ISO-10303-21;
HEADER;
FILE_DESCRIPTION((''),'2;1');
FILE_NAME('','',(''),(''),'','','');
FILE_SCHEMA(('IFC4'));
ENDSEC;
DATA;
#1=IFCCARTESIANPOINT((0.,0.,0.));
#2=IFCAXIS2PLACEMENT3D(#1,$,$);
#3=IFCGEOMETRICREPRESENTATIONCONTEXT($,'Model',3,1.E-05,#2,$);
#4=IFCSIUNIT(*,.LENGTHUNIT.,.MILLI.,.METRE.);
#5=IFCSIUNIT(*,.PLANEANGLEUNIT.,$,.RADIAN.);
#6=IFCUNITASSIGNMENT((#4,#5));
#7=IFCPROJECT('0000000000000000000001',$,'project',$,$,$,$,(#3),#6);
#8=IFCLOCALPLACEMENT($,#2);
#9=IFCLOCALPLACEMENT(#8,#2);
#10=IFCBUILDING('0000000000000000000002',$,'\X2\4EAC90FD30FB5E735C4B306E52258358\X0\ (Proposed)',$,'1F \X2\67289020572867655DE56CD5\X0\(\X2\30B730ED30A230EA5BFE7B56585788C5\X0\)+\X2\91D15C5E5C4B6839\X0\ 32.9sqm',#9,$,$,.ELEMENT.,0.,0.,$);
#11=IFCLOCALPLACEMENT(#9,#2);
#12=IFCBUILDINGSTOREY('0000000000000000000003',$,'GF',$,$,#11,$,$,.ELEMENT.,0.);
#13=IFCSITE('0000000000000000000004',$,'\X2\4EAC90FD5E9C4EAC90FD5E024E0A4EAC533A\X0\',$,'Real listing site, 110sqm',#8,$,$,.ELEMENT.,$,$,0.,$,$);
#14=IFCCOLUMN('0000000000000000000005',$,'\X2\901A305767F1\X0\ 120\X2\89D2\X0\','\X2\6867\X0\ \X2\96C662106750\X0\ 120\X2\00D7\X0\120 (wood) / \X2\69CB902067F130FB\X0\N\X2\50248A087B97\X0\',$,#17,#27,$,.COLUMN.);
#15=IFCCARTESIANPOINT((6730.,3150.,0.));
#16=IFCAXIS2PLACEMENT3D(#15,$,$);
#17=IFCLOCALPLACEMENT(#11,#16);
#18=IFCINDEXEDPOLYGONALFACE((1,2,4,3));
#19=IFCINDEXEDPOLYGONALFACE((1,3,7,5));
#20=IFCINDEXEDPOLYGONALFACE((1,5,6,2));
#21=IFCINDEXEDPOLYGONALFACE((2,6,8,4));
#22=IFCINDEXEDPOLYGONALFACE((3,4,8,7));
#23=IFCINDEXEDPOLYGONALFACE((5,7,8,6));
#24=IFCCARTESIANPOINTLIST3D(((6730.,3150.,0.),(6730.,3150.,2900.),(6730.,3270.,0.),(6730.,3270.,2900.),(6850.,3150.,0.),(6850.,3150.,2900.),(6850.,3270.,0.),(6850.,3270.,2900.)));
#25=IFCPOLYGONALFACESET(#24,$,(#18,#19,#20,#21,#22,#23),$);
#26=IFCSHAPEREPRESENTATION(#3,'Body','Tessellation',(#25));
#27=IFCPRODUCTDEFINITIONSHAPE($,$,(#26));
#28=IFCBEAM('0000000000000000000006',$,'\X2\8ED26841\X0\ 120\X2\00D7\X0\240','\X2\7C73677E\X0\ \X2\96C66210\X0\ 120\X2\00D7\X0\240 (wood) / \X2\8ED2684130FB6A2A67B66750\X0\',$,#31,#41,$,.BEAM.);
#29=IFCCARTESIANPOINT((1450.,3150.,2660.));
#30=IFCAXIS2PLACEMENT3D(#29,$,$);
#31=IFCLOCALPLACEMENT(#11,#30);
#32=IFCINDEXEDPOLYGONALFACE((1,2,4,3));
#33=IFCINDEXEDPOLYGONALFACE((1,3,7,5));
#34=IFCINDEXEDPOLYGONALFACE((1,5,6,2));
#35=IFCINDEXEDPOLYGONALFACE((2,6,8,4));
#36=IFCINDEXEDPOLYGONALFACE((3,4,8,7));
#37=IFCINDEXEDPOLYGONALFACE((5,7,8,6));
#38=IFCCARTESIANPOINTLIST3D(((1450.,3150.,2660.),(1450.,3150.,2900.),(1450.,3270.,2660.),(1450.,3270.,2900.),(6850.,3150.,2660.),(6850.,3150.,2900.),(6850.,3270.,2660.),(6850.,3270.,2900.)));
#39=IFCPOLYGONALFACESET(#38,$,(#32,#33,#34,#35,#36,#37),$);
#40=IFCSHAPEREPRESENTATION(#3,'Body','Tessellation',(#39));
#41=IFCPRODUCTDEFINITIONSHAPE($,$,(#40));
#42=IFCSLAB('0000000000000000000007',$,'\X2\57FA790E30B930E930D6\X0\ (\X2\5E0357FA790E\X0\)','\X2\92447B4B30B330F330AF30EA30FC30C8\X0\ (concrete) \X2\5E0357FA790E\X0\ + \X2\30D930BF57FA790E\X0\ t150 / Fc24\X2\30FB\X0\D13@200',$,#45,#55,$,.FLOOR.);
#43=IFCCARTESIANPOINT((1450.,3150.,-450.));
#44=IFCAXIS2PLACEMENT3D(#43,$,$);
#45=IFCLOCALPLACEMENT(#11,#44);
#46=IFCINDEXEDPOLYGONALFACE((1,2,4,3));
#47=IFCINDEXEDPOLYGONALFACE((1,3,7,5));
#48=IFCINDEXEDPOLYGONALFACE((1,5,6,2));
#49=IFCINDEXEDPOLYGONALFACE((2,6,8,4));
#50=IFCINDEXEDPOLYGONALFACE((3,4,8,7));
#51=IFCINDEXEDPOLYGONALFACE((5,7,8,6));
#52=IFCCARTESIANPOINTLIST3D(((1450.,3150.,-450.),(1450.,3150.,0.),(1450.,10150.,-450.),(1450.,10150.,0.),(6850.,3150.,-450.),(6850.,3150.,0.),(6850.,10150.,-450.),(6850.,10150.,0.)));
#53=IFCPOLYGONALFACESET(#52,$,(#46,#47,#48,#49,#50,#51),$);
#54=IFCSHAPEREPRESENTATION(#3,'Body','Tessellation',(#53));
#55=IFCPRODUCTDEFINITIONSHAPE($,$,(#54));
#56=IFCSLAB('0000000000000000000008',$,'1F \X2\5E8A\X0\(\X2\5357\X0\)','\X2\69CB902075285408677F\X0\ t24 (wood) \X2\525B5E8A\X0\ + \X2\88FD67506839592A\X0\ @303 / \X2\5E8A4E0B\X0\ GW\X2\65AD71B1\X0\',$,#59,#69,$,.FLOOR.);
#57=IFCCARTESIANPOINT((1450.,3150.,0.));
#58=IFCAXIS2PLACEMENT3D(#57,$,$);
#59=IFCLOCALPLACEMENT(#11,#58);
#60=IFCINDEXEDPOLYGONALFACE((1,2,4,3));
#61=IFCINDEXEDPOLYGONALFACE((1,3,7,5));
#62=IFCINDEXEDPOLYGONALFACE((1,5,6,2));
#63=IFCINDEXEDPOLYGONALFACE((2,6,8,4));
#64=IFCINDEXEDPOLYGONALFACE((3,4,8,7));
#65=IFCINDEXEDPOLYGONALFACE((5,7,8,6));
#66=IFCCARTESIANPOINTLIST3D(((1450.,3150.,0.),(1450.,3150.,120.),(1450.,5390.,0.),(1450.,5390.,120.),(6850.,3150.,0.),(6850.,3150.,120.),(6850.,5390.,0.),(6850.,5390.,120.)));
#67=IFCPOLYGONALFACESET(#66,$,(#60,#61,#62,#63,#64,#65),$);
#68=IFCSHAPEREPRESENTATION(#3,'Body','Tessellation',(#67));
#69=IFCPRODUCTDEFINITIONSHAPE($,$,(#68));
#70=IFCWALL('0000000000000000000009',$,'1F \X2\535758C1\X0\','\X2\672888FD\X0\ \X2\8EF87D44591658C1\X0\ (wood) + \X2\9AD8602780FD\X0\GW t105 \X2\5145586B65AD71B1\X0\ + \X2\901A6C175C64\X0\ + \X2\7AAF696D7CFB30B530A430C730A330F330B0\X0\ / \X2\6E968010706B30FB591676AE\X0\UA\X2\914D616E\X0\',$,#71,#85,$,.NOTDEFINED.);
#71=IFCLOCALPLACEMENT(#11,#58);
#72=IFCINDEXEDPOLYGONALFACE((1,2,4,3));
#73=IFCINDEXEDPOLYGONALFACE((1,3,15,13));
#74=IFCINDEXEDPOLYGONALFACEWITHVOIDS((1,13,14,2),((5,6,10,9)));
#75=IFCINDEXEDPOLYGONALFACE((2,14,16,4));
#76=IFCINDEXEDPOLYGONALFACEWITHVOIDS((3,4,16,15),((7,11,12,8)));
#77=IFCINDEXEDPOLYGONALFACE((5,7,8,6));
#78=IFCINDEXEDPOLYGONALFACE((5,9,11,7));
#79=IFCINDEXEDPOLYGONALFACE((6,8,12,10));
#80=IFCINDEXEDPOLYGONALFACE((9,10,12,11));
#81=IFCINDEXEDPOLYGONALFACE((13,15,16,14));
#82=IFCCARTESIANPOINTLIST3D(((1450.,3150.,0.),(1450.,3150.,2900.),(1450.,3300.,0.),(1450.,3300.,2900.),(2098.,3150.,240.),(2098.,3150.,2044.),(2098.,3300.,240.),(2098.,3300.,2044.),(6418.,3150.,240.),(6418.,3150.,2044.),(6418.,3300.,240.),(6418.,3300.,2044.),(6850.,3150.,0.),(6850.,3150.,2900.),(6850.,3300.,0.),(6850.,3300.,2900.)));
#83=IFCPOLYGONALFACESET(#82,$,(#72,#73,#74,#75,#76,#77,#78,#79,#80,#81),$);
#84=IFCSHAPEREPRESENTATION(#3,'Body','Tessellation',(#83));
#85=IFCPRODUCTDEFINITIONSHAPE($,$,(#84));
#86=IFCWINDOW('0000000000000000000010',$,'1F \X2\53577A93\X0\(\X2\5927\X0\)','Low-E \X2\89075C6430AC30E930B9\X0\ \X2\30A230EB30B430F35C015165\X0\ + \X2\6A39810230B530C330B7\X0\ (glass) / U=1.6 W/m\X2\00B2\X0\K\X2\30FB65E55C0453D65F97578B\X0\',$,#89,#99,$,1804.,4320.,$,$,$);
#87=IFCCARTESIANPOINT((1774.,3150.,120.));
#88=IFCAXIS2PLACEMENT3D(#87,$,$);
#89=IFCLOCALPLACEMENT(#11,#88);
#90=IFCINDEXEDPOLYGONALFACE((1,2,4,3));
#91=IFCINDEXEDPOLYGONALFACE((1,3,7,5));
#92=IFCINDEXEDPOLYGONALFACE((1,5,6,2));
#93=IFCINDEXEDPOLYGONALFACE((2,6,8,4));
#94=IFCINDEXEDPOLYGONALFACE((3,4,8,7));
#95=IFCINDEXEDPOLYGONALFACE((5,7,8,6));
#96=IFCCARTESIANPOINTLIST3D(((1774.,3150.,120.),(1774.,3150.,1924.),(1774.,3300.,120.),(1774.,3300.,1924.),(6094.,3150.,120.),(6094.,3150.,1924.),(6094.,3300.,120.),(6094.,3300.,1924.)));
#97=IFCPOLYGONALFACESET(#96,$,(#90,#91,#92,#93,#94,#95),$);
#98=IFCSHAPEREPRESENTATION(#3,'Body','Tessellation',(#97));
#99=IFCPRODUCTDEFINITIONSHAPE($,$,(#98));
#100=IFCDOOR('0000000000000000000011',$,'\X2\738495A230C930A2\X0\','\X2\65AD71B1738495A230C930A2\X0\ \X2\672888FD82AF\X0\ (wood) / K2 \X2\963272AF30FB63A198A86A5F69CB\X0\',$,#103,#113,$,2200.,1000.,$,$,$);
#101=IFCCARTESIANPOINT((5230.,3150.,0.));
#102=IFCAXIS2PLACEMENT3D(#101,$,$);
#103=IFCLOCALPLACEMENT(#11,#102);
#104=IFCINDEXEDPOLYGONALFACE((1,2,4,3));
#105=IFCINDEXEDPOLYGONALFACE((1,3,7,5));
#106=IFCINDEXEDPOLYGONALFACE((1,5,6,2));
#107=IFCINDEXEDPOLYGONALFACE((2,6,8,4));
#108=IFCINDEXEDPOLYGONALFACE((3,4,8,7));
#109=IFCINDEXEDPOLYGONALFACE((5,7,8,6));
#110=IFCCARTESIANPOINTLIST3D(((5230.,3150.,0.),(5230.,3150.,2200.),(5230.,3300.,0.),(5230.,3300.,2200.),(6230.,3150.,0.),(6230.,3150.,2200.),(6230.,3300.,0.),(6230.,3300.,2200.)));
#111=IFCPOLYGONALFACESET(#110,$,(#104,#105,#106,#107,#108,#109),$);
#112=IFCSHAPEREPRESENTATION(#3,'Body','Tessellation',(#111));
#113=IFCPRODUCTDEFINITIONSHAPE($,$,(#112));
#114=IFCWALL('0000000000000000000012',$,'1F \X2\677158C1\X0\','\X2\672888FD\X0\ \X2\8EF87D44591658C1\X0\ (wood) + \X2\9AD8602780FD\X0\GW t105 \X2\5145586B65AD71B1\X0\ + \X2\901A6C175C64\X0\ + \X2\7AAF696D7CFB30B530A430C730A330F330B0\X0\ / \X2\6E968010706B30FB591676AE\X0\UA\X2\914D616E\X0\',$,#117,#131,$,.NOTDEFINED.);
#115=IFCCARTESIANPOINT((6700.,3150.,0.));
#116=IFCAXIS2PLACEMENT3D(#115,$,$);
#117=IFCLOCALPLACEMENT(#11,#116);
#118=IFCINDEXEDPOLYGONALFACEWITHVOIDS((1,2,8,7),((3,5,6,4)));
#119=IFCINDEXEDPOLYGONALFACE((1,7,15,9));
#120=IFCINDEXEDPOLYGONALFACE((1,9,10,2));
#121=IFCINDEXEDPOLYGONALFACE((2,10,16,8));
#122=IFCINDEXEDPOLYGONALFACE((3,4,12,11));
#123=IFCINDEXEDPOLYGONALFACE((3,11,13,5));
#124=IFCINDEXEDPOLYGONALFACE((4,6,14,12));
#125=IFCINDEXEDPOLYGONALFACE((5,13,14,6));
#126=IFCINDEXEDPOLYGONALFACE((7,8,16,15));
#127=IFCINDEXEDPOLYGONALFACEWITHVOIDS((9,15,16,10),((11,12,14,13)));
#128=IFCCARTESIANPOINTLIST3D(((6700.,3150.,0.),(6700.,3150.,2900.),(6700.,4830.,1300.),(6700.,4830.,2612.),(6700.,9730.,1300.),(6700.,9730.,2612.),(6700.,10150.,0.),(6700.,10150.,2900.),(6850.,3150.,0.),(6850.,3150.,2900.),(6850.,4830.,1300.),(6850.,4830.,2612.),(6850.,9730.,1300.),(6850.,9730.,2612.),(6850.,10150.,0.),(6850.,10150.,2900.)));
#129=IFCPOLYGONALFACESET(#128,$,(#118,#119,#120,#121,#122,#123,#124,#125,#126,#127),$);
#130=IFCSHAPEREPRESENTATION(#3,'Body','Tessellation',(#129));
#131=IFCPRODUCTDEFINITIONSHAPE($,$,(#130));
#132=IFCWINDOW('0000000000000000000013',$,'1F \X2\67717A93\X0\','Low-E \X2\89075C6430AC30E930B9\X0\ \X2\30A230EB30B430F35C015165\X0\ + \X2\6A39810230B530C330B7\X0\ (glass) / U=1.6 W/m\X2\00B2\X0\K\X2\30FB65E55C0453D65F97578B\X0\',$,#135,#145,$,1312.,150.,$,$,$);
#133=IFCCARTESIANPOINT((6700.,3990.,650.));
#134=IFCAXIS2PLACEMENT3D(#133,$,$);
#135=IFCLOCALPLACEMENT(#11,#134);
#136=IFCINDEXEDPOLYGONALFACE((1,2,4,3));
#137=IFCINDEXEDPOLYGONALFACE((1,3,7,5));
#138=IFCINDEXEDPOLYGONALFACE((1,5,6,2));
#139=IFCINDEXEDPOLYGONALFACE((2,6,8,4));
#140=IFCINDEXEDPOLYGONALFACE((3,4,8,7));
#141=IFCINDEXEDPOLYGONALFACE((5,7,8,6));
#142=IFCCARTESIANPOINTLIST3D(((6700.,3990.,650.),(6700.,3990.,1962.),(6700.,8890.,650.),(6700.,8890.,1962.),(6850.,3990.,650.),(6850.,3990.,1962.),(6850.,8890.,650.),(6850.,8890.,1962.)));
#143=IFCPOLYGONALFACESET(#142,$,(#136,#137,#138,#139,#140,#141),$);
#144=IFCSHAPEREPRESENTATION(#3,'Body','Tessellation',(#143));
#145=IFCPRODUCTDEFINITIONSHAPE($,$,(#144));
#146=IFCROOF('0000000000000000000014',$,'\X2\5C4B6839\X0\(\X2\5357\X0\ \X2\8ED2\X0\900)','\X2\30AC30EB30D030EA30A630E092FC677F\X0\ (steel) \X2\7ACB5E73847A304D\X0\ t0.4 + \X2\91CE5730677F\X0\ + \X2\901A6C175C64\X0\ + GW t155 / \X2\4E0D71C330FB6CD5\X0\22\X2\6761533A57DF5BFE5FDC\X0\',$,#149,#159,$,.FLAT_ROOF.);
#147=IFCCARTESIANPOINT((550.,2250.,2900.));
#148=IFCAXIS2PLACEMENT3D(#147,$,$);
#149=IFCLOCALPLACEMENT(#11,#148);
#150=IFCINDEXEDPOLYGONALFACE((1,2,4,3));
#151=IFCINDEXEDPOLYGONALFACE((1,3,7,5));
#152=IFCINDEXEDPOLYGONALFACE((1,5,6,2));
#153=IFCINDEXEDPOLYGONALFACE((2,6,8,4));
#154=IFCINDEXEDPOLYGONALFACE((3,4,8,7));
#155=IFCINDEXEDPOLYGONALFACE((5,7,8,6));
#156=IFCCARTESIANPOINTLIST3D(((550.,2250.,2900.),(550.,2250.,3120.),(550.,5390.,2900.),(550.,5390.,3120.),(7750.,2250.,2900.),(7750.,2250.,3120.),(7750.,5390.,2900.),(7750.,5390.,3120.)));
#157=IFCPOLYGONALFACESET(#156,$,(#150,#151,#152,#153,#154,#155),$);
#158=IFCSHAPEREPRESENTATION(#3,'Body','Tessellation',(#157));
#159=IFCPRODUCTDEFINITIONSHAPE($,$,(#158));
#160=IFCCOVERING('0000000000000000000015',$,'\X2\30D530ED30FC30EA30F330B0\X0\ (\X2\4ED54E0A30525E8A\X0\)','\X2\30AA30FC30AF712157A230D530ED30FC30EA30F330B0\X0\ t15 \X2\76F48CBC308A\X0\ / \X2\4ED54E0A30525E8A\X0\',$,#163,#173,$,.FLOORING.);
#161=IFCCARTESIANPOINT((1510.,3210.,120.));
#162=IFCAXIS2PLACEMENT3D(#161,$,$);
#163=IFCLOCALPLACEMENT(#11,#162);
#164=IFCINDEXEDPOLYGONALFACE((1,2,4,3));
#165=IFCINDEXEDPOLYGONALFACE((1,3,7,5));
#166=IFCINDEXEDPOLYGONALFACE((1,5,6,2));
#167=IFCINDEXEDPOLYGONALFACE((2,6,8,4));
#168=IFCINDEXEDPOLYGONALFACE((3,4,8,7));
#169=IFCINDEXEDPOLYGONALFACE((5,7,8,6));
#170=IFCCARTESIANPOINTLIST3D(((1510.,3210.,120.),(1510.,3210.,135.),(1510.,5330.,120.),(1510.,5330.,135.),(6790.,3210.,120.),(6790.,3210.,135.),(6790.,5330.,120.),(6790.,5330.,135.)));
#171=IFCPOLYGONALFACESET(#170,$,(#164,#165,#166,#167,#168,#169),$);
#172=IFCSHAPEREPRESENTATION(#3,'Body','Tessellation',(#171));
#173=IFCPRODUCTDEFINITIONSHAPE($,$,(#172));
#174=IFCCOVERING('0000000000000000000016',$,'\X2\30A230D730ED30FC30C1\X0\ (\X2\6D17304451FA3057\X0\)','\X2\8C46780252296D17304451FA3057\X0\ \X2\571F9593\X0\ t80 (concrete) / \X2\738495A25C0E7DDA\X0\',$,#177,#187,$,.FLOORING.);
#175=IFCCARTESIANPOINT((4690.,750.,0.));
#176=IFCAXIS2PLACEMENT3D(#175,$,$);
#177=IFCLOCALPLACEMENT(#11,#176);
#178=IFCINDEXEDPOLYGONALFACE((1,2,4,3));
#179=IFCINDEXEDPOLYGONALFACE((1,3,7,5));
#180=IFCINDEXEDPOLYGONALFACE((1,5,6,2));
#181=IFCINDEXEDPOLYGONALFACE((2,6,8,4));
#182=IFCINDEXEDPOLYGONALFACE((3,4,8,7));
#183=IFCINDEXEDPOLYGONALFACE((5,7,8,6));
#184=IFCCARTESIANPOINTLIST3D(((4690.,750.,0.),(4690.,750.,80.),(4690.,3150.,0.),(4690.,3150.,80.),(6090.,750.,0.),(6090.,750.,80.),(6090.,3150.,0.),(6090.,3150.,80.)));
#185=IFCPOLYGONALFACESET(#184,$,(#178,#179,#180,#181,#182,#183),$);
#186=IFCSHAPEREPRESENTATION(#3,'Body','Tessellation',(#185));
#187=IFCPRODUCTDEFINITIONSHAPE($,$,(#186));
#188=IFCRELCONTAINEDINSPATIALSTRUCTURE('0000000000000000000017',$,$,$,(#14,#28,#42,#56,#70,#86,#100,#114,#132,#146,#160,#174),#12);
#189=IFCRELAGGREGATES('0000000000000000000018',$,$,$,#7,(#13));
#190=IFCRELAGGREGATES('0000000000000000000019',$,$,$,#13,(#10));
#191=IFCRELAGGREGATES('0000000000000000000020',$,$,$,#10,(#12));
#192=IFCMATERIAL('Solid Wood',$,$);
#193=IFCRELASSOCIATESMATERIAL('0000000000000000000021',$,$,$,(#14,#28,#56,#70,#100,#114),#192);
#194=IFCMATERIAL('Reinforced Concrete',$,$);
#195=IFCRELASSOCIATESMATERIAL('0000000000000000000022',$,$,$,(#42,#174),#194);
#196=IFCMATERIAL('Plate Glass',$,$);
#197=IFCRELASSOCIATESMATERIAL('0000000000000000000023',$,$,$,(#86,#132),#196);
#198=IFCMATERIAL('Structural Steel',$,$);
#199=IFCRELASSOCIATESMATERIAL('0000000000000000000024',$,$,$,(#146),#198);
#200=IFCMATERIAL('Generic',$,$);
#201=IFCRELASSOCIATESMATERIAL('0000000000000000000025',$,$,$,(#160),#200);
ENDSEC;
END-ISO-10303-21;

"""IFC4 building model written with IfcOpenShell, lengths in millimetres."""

from ifc_helpers import new_model, si_unit, frame, frame_2d, origin, place, context, project, spatial, rectangle, extrude, material, element, fill, save


model = new_model("IFC4")

# Units and contexts
model_context = context("Model", 3, precision=1e-05, world=origin())
ifc_project = project(units=[si_unit("LENGTHUNIT", "METRE", prefix="MILLI"), si_unit("PLANEANGLEUNIT", "RADIAN")], contexts=[model_context])

# Site, building, storey
site_placement = place(None, origin())
site = spatial("IfcSite", under=ifc_project, at=site_placement, Name="京都府京都市上京区", ObjectType="Real listing site, 110sqm", CompositionType="ELEMENT", RefElevation=0.0)
building_placement = place(site_placement, origin())
building = spatial("IfcBuilding", under=site, at=building_placement, Name="京都・平屋の別荘 (Proposed)", ObjectType="1F 木造在来工法(シロアリ対策塗装)+金属屋根 32.9sqm", CompositionType="ELEMENT", ElevationOfRefHeight=0.0, ElevationOfTerrain=0.0)
storey_placement = place(building_placement, origin())
storey = spatial("IfcBuildingStorey", under=building, at=storey_placement, Name="GF", CompositionType="ELEMENT", Elevation=0.0)

# Column
ifc_material_1 = material(Name="Solid Wood")
column_1_placement = place(storey_placement, frame((6730.0, 3150.0, 0.0)))
element("IfcColumn", 1, at=column_1_placement, inside=storey, material=ifc_material_1, Name="通し柱 120角", Description="桧 集成材 120×120 (wood) / 構造柱・N値計算", PredefinedType="COLUMN", context=model_context, shape_type="SweptSolid", body=[
    extrude(rectangle(XDim=120.0, YDim=120.0, at=frame_2d((60.0, 60.0))), frame((6730.0, 3150.0, 0.0)), (0.0, 0.0, 1.0), 2900.0),
])

# Beam
beam_1_placement = place(storey_placement, frame((1450.0, 3150.0, 2660.0)))
element("IfcBeam", 2, at=beam_1_placement, inside=storey, material=ifc_material_1, Name="軒桁 120×240", Description="米松 集成 120×240 (wood) / 軒桁・横架材", PredefinedType="BEAM", context=model_context, shape_type="SweptSolid", body=[
    extrude(rectangle(XDim=5400.0, YDim=120.0, at=frame_2d((2700.0, 60.0))), frame((1450.0, 3150.0, 2660.0)), (0.0, 0.0, 1.0), 240.0),
])

# Slabs
ifc_material_2 = material(Name="Reinforced Concrete")
slab_1_placement = place(storey_placement, frame((1450.0, 3150.0, -450.0)))
element("IfcSlab", 3, at=slab_1_placement, inside=storey, material=ifc_material_2, Name="基礎スラブ (布基礎)", Description="鉄筋コンクリート (concrete) 布基礎 + ベタ基礎 t150 / Fc24・D13@200", PredefinedType="FLOOR", context=model_context, shape_type="SweptSolid", body=[
    extrude(rectangle(XDim=5400.0, YDim=7000.0, at=frame_2d((2700.0, 3500.0))), frame((1450.0, 3150.0, -450.0)), (0.0, 0.0, 1.0), 450.0),
])
slab_2_placement = place(storey_placement, frame((1450.0, 3150.0, 0.0)))
element("IfcSlab", 4, at=slab_2_placement, inside=storey, material=ifc_material_1, Name="1F 床(南)", Description="構造用合板 t24 (wood) 剛床 + 製材根太 @303 / 床下 GW断熱", PredefinedType="FLOOR", context=model_context, shape_type="SweptSolid", body=[
    extrude(rectangle(XDim=5400.0, YDim=2240.0, at=frame_2d((2700.0, 1120.0))), frame((1450.0, 3150.0, 0.0)), (0.0, 0.0, 1.0), 120.0),
])

# Wall, openings, window, door
wall_1_placement = place(storey_placement, frame((1450.0, 3150.0, 0.0)))
wall_1 = element("IfcWall", 5, at=wall_1_placement, inside=storey, material=ifc_material_1, Name="1F 南壁", Description="木製 軸組外壁 (wood) + 高性能GW t105 充填断熱 + 通気層 + 窯業系サイディング / 準耐火・外皮UA配慮", PredefinedType="NOTDEFINED", context=model_context, shape_type="SweptSolid", body=[
    extrude(rectangle(XDim=5400.0, YDim=150.0, at=frame_2d((2700.0, 75.0))), frame((1450.0, 3150.0, 0.0)), (0.0, 0.0, 1.0), 2900.0),
])
opening_1_placement = place(storey_placement, frame((1774.0, 3150.0, 120.0)))
opening_1 = element("IfcOpeningElement", 6, at=opening_1_placement, cuts=wall_1, PredefinedType="NOTDEFINED", context=model_context, shape_type="SweptSolid", body=[
    extrude(rectangle(XDim=4320.0, YDim=150.0, at=frame_2d((2160.0, 75.0))), frame((1774.0, 3150.0, 120.0)), (0.0, 0.0, 1.0), 1804.0),
])
opening_2_placement = place(storey_placement, frame((5230.0, 3150.0, 0.0)))
opening_2 = element("IfcOpeningElement", 7, at=opening_2_placement, cuts=wall_1, PredefinedType="NOTDEFINED", context=model_context, shape_type="SweptSolid", body=[
    extrude(rectangle(XDim=1000.0, YDim=150.0, at=frame_2d((500.0, 75.0))), frame((5230.0, 3150.0, 0.0)), (0.0, 0.0, 1.0), 2200.0),
])
ifc_material_3 = material(Name="Plate Glass")
window_1_placement = place(storey_placement, frame((1774.0, 3150.0, 120.0)))
window_1 = element("IfcWindow", 8, at=window_1_placement, inside=storey, material=ifc_material_3, Name="1F 南窓(大)", Description="Low-E 複層ガラス アルゴン封入 + 樹脂サッシ (glass) / U=1.6 W/m²K・日射取得型", OverallHeight=1804.0, OverallWidth=4320.0, context=model_context, shape_type="SweptSolid", body=[
    extrude(rectangle(XDim=4320.0, YDim=150.0, at=frame_2d((2160.0, 75.0))), frame((1774.0, 3150.0, 120.0)), (0.0, 0.0, 1.0), 1804.0),
])
fill(opening_1, window_1)
door_placement = place(storey_placement, frame((5230.0, 3150.0, 0.0)))
door = element("IfcDoor", 9, at=door_placement, inside=storey, material=ifc_material_1, Name="玄関ドア", Description="断熱玄関ドア 木製芯 (wood) / K2 防犯・採風機構", OverallHeight=2200.0, OverallWidth=1000.0, context=model_context, shape_type="SweptSolid", body=[
    extrude(rectangle(XDim=1000.0, YDim=150.0, at=frame_2d((500.0, 75.0))), frame((5230.0, 3150.0, 0.0)), (0.0, 0.0, 1.0), 2200.0),
])
fill(opening_2, door)

# Wall, opening, window
wall_2_placement = place(storey_placement, frame((6700.0, 3150.0, 0.0)))
wall_2 = element("IfcWall", 10, at=wall_2_placement, inside=storey, material=ifc_material_1, Name="1F 東壁", Description="木製 軸組外壁 (wood) + 高性能GW t105 充填断熱 + 通気層 + 窯業系サイディング / 準耐火・外皮UA配慮", PredefinedType="NOTDEFINED", context=model_context, shape_type="SweptSolid", body=[
    extrude(rectangle(XDim=150.0, YDim=7000.0, at=frame_2d((75.0, 3500.0))), frame((6700.0, 3150.0, 0.0)), (0.0, 0.0, 1.0), 2900.0),
])
opening_3_placement = place(storey_placement, frame((6700.0, 3990.0, 650.0)))
opening_3 = element("IfcOpeningElement", 11, at=opening_3_placement, cuts=wall_2, PredefinedType="NOTDEFINED", context=model_context, shape_type="SweptSolid", body=[
    extrude(rectangle(XDim=150.0, YDim=4900.0, at=frame_2d((75.0, 2450.0))), frame((6700.0, 3990.0, 650.0)), (0.0, 0.0, 1.0), 1312.0),
])
window_2_placement = place(storey_placement, frame((6700.0, 3990.0, 650.0)))
window_2 = element("IfcWindow", 12, at=window_2_placement, inside=storey, material=ifc_material_3, Name="1F 東窓", Description="Low-E 複層ガラス アルゴン封入 + 樹脂サッシ (glass) / U=1.6 W/m²K・日射取得型", OverallHeight=1312.0, OverallWidth=150.0, context=model_context, shape_type="SweptSolid", body=[
    extrude(rectangle(XDim=150.0, YDim=4900.0, at=frame_2d((75.0, 2450.0))), frame((6700.0, 3990.0, 650.0)), (0.0, 0.0, 1.0), 1312.0),
])
fill(opening_3, window_2)

# Roof
ifc_material_4 = material(Name="Structural Steel")
roof_placement = place(storey_placement, frame((550.0, 2250.0, 2900.0)))
element("IfcRoof", 13, at=roof_placement, inside=storey, material=ifc_material_4, Name="屋根(南 軒900)", Description="ガルバリウム鋼板 (steel) 立平葺き t0.4 + 野地板 + 通気層 + GW t155 / 不燃・法22条区域対応", PredefinedType="FLAT_ROOF", context=model_context, shape_type="SweptSolid", body=[
    extrude(rectangle(XDim=7200.0, YDim=3140.0, at=frame_2d((3600.0, 1570.0))), frame((550.0, 2250.0, 2900.0)), (0.0, 0.0, 1.0), 220.0),
])

# Coverings
ifc_material_5 = material(Name="Generic")
covering_1_placement = place(storey_placement, frame((1510.0, 3210.0, 120.0)))
element("IfcCovering", 14, at=covering_1_placement, inside=storey, material=ifc_material_5, Name="フローリング (仕上げ床)", Description="オーク無垢フローリング t15 直貼り / 仕上げ床", PredefinedType="FLOORING", context=model_context, shape_type="SweptSolid", body=[
    extrude(rectangle(XDim=5280.0, YDim=2120.0, at=frame_2d((2640.0, 1060.0))), frame((1510.0, 3210.0, 120.0)), (0.0, 0.0, 1.0), 15.0),
])
covering_2_placement = place(storey_placement, frame((4690.0, 750.0, 0.0)))
element("IfcCovering", 15, at=covering_2_placement, inside=storey, material=ifc_material_2, Name="アプローチ (洗い出し)", Description="豆砂利洗い出し 土間 t80 (concrete) / 玄関導線", PredefinedType="FLOORING", context=model_context, shape_type="SweptSolid", body=[
    extrude(rectangle(XDim=1400.0, YDim=2400.0, at=frame_2d((700.0, 1200.0))), frame((4690.0, 750.0, 0.0)), (0.0, 0.0, 1.0), 80.0),
])

save(model, "model.ifc")
